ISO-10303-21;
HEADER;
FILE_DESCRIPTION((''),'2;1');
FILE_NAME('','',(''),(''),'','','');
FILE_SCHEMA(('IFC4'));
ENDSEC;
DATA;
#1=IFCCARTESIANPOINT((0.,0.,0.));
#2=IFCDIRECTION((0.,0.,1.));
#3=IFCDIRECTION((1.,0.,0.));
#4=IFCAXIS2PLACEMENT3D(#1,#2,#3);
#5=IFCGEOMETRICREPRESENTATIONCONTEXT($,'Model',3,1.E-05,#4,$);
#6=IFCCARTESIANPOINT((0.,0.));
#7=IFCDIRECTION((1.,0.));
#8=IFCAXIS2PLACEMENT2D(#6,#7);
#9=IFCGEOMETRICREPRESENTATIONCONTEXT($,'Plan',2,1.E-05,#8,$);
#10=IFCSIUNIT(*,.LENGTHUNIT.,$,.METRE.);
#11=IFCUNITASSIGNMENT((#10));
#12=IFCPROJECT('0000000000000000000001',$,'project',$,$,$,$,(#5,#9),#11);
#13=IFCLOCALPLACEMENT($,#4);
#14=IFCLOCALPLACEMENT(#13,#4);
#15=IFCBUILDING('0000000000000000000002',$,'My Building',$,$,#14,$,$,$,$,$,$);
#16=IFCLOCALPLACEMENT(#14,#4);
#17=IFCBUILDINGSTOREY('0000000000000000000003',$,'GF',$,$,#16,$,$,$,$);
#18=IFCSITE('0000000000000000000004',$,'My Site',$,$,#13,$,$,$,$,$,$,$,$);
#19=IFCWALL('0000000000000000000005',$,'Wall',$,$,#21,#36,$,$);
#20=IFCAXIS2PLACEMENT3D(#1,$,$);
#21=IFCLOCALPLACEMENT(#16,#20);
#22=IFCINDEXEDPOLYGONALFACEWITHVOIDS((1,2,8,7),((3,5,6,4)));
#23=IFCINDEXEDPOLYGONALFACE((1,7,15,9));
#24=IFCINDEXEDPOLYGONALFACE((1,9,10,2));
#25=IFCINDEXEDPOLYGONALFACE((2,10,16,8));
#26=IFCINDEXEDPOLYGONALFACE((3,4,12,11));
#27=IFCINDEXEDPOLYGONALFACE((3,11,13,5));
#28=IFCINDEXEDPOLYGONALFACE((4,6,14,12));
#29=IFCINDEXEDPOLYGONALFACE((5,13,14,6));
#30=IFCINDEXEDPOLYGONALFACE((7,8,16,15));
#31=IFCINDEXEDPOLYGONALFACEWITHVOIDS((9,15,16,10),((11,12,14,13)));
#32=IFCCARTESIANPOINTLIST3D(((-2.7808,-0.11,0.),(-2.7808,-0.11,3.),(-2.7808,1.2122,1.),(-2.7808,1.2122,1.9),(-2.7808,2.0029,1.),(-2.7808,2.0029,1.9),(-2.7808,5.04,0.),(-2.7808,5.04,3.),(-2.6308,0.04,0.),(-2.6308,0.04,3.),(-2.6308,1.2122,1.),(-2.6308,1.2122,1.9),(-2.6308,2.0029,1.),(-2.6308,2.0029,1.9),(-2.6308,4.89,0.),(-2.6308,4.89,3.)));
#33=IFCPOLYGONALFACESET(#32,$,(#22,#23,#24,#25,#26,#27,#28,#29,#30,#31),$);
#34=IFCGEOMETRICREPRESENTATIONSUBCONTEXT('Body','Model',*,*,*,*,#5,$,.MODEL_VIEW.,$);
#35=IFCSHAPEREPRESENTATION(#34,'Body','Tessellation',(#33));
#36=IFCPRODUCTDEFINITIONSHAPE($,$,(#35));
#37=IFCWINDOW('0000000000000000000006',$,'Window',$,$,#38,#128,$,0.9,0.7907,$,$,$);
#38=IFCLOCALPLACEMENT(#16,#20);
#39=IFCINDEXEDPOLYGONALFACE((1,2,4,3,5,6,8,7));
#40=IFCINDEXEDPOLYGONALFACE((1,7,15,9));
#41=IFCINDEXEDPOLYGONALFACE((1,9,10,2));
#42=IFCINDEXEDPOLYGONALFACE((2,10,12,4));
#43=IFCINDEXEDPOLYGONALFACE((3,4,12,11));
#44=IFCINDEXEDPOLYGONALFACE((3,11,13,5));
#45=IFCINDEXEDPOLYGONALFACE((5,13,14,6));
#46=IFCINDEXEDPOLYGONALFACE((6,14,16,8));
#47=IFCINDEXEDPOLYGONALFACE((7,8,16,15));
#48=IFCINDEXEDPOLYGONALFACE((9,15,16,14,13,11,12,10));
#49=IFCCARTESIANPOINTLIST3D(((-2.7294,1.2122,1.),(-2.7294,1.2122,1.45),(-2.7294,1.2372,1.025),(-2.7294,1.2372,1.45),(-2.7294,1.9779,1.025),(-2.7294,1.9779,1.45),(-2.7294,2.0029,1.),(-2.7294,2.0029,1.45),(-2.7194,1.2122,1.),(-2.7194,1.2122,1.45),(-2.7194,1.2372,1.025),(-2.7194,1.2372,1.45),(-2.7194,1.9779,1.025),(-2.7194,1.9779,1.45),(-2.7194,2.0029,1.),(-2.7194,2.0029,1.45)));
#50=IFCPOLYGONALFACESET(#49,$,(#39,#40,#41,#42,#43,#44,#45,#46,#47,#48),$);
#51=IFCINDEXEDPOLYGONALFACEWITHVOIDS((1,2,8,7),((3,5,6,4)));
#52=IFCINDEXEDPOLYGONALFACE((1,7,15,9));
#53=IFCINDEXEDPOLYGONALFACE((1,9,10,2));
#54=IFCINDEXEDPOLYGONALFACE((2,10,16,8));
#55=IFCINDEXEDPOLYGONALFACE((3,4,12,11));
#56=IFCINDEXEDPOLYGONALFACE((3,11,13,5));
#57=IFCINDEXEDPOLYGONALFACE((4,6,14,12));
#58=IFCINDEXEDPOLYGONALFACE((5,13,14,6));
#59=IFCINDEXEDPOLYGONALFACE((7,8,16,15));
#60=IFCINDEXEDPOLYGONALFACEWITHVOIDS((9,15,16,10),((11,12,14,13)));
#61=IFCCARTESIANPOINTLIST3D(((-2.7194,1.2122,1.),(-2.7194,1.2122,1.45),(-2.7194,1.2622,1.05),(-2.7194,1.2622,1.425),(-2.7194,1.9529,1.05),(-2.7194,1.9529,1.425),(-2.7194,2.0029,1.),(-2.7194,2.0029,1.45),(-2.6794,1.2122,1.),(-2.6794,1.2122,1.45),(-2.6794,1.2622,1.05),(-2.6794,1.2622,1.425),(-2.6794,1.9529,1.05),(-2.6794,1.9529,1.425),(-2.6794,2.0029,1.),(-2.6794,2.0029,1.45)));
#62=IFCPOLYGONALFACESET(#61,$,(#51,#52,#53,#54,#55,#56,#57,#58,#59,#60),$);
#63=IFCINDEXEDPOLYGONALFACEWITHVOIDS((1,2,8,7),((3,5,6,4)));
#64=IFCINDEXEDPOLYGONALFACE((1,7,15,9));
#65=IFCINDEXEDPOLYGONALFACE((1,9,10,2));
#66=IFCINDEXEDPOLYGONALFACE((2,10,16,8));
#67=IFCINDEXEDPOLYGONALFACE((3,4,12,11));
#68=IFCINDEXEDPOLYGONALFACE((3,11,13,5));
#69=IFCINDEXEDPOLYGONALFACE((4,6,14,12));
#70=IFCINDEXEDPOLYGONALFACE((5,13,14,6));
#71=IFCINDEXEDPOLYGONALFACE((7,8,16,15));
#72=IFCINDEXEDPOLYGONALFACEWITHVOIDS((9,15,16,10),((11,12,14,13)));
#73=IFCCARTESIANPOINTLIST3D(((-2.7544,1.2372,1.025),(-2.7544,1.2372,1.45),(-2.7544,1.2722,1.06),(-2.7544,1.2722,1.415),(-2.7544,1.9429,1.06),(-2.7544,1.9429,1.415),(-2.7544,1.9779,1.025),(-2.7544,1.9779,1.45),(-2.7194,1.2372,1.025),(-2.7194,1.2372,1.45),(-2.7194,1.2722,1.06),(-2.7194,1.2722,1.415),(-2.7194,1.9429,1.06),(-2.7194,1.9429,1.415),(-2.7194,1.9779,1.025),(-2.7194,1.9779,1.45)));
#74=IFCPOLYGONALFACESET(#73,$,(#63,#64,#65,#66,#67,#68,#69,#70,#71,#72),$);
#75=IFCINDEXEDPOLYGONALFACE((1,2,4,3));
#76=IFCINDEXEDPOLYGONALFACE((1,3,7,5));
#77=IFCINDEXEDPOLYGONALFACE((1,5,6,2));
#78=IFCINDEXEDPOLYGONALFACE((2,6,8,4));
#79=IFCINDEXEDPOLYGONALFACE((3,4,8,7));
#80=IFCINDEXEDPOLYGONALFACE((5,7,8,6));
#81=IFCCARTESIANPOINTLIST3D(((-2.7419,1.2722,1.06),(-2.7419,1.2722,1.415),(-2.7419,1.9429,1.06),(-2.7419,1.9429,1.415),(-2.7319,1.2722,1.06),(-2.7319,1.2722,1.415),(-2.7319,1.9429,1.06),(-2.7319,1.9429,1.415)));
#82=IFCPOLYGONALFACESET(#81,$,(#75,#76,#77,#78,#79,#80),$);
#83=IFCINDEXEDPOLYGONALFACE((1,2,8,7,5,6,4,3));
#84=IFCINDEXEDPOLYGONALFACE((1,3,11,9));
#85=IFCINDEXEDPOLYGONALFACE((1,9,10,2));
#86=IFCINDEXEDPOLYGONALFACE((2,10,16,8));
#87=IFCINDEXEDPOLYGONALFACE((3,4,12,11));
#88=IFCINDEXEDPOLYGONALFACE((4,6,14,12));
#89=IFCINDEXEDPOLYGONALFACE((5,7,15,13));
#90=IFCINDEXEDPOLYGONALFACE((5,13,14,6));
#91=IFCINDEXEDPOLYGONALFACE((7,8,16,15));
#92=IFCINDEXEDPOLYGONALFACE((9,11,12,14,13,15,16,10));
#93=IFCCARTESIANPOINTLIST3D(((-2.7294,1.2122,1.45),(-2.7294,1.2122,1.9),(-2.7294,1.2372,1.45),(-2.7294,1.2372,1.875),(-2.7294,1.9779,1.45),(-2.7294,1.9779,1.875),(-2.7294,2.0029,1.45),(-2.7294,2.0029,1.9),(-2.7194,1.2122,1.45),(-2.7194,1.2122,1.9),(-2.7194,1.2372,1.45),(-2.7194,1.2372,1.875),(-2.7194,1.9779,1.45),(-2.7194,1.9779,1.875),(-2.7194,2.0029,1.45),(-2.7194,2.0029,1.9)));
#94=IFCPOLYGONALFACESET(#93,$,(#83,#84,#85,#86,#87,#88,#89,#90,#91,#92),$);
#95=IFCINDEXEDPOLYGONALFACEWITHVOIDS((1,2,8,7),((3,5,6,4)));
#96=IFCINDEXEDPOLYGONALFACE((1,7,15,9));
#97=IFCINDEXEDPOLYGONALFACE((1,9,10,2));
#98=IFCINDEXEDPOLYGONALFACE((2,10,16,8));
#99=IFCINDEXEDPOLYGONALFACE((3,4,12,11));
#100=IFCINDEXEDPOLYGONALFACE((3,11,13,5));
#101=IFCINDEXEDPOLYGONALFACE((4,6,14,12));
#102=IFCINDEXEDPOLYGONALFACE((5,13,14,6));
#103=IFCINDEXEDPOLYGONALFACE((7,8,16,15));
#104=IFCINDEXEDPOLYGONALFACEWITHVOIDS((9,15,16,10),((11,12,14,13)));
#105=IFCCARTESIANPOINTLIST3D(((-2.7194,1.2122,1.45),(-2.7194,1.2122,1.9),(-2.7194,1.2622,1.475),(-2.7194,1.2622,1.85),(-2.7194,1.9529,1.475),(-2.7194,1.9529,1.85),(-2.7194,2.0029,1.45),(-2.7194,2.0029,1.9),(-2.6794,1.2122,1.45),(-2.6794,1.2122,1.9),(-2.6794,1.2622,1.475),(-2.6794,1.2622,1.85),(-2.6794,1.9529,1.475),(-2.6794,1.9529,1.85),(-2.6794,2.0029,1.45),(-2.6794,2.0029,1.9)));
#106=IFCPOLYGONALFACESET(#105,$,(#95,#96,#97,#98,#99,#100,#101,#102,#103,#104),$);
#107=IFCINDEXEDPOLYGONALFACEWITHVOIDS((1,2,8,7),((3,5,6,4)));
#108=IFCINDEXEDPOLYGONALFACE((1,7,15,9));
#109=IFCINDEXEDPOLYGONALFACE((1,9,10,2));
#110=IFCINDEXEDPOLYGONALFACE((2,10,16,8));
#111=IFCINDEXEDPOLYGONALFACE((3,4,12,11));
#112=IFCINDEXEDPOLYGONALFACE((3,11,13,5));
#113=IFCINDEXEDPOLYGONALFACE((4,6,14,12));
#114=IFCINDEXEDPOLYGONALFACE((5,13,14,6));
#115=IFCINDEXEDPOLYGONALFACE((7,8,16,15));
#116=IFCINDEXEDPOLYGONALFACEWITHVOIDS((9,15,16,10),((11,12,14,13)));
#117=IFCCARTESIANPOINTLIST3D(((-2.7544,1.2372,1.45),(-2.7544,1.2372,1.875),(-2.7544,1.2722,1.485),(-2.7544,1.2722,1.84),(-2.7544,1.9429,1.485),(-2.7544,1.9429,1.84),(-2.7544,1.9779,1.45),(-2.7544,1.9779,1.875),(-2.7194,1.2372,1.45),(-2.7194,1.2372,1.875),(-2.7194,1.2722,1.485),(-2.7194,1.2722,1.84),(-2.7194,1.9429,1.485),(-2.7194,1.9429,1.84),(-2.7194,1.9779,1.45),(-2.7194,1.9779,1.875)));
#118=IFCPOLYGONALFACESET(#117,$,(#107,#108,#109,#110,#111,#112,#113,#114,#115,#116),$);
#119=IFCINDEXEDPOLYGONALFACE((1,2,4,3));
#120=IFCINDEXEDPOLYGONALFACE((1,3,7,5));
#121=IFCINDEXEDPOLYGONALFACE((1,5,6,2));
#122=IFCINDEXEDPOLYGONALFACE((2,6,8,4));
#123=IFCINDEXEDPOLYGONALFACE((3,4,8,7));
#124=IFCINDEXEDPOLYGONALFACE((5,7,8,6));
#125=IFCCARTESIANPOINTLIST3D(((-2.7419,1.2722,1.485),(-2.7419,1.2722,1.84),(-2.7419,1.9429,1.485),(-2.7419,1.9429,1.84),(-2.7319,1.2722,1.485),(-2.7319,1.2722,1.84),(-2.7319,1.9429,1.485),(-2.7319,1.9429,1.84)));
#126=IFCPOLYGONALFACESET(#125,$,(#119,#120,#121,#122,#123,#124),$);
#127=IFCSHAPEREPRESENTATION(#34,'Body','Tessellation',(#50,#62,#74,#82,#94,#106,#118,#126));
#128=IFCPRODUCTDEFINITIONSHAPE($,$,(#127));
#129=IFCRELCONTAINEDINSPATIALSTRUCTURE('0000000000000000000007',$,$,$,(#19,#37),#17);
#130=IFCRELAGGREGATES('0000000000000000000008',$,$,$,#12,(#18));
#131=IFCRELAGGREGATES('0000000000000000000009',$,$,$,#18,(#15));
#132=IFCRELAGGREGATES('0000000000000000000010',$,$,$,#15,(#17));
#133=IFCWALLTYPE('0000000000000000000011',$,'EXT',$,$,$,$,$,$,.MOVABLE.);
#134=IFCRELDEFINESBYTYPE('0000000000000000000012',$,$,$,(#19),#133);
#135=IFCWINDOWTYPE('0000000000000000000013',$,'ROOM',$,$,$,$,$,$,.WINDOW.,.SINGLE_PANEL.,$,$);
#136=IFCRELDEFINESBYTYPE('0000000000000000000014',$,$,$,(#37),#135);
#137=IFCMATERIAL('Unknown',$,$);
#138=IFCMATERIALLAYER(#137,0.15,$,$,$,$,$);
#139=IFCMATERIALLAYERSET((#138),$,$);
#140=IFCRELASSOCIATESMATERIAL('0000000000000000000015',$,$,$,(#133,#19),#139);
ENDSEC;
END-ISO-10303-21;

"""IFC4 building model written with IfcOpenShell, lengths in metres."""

from ifc_helpers import new_model, entity, si_unit, frame, origin_with_axes, origin_2d_with_axis, place, context, subcontext, project, spatial, line, indexed_curve, outline, extrude, shape, source, transform, mapped, material, layer, layer_set, layer_usage, type_object, type_shapes, element, fill, save


model = new_model("IFC4")

# Units and contexts
model_context = context("Model", 3, precision=1e-05, world=origin_with_axes())
plan_context = context("Plan", 2, precision=1e-05, world=origin_2d_with_axis())
body_context_1 = subcontext(model_context, "Body", "Model", "MODEL_VIEW")
body_context_2 = subcontext(plan_context, "Body", "Plan", "PLAN_VIEW")
ifc_project = project(units=[si_unit("LENGTHUNIT", "METRE")], contexts=[model_context, plan_context])

# Site, building, storey
site_placement = place(None, origin_with_axes())
site = spatial("IfcSite", under=ifc_project, at=site_placement, Name="My Site")
building_placement = place(site_placement, origin_with_axes())
building = spatial("IfcBuilding", under=site, at=building_placement, Name="My Building")
storey_placement = place(building_placement, origin_with_axes())
storey = spatial("IfcBuildingStorey", under=building, at=storey_placement, Name="GF")

# Shared definitions
ifc_material = material(Name="Unknown")

# Shared definitions
ifc_layer_1 = layer(ifc_material, 0.15)
ifc_layer_set_1 = layer_set([ifc_layer_1])
wall_type_1 = type_object("IfcWallType", Name="EXT", PredefinedType="MOVABLE", material=ifc_layer_set_1)
window_type_1 = type_object("IfcWindowType", Name="ROOM", PartitioningType="SINGLE_PANEL", PredefinedType="WINDOW")
shared_shape_1 = source(origin_with_axes(), body_context_1, "Body", "SweptSolid", [
    extrude(outline(indexed_curve([(0.7907, 0.45), (0.7907, 0.0), (0.0, 0.0), (0.0, 0.45), (0.025, 0.45), (0.025, 0.025), (0.7657, 0.025), (0.7657, 0.45)], segments=[line(1, 2, 3, 4, 5, 6, 7, 8, 1)])), frame((0.0, 0.09, 0.0), z_axis=(0.0, -1.0, 0.0), x_axis=(1.0, 0.0, 0.0)), (0.0, 0.0, -1.0), 0.01),
    extrude(outline(indexed_curve([(0.0, 0.0), (0.7907, 0.0), (0.7907, 0.45), (0.0, 0.45)], segments=[line(1, 2, 3, 4, 1)]), holes=[indexed_curve([(0.05, 0.05), (0.7407, 0.05), (0.7407, 0.425), (0.05, 0.425)], segments=[line(1, 2, 3, 4, 1)])]), frame((0.0, 0.05, 0.0), z_axis=(0.0, -1.0, 0.0), x_axis=(1.0, 0.0, 0.0)), (0.0, 0.0, -1.0), 0.04),
    extrude(outline(indexed_curve([(0.0, 0.0), (0.7407, 0.0), (0.7407, 0.425), (0.0, 0.425)], segments=[line(1, 2, 3, 4, 1)]), holes=[indexed_curve([(0.035, 0.035), (0.7057, 0.035), (0.7057, 0.39), (0.035, 0.39)], segments=[line(1, 2, 3, 4, 1)])]), frame((0.025, 0.09, 0.025), z_axis=(0.0, -1.0, 0.0), x_axis=(1.0, 0.0, 0.0)), (0.0, 0.0, -1.0), 0.035),
    extrude(outline(indexed_curve([(0.035, 0.035), (0.7057, 0.035), (0.7057, 0.39), (0.035, 0.39)], segments=[line(1, 2, 3, 4, 1)])), frame((0.025, 0.1025, 0.025), z_axis=(0.0, -1.0, 0.0), x_axis=(1.0, 0.0, 0.0)), (0.0, 0.0, -1.0), 0.01),
    extrude(outline(indexed_curve([(0.0, 0.0), (0.0, 0.45), (0.7907, 0.45), (0.7907, 0.0), (0.7657, 0.0), (0.7657, 0.425), (0.025, 0.425), (0.025, 0.0)], segments=[line(1, 2, 3, 4, 5, 6, 7, 8, 1)])), frame((0.0, 0.09, 0.45), z_axis=(0.0, -1.0, 0.0), x_axis=(1.0, 0.0, 0.0)), (0.0, 0.0, -1.0), 0.01),
    extrude(outline(indexed_curve([(0.0, 0.0), (0.7907, 0.0), (0.7907, 0.45), (0.0, 0.45)], segments=[line(1, 2, 3, 4, 1)]), holes=[indexed_curve([(0.05, 0.025), (0.7407, 0.025), (0.7407, 0.4), (0.05, 0.4)], segments=[line(1, 2, 3, 4, 1)])]), frame((0.0, 0.05, 0.45), z_axis=(0.0, -1.0, 0.0), x_axis=(1.0, 0.0, 0.0)), (0.0, 0.0, -1.0), 0.04),
    extrude(outline(indexed_curve([(0.0, 0.0), (0.7407, 0.0), (0.7407, 0.425), (0.0, 0.425)], segments=[line(1, 2, 3, 4, 1)]), holes=[indexed_curve([(0.035, 0.035), (0.7057, 0.035), (0.7057, 0.39), (0.035, 0.39)], segments=[line(1, 2, 3, 4, 1)])]), frame((0.025, 0.09, 0.45), z_axis=(0.0, -1.0, 0.0), x_axis=(1.0, 0.0, 0.0)), (0.0, 0.0, -1.0), 0.035),
    extrude(outline(indexed_curve([(0.035, 0.035), (0.7057, 0.035), (0.7057, 0.39), (0.035, 0.39)], segments=[line(1, 2, 3, 4, 1)])), frame((0.025, 0.1025, 0.45), z_axis=(0.0, -1.0, 0.0), x_axis=(1.0, 0.0, 0.0)), (0.0, 0.0, -1.0), 0.01),
])
shared_shape_2 = source(origin_with_axes(), body_context_2, "Body", "Curve2D", [
    entity("IfcIndexedPolyCurve", entity("IfcCartesianPointList2D", [[0.05, 0.05], [0.7407, 0.05]])),
    entity("IfcIndexedPolyCurve", entity("IfcCartesianPointList2D", [[0.0, 0.1], [0.025, 0.1], [0.025, 0.09], [0.05, 0.09], [0.05, 0.05], [0.0, 0.05]]), [entity("IfcLineIndex", [1, 2, 3, 4, 5, 6, 1])]),
    entity("IfcIndexedPolyCurve", entity("IfcCartesianPointList2D", [[0.7907, 0.1], [0.7657, 0.1], [0.7657, 0.09], [0.7407, 0.09], [0.7407, 0.05], [0.7907, 0.05]]), [entity("IfcLineIndex", [1, 2, 3, 4, 5, 6, 1])]),
    entity("IfcIndexedPolyCurve", entity("IfcCartesianPointList2D", [[0.025, 0.09], [0.06, 0.09], [0.06, 0.125], [0.025, 0.125]]), [entity("IfcLineIndex", [1, 2, 3, 4, 1])]),
    entity("IfcIndexedPolyCurve", entity("IfcCartesianPointList2D", [[0.7657, 0.09], [0.7307, 0.09], [0.7307, 0.125], [0.7657, 0.125]]), [entity("IfcLineIndex", [1, 2, 3, 4, 1])]),
    entity("IfcIndexedPolyCurve", entity("IfcCartesianPointList2D", [[0.06, 0.09], [0.7307, 0.09]])),
    entity("IfcIndexedPolyCurve", entity("IfcCartesianPointList2D", [[0.06, 0.125], [0.7307, 0.125]])),
    entity("IfcIndexedPolyCurve", entity("IfcCartesianPointList2D", [[0.06, 0.1075], [0.7307, 0.1075]])),
])
type_shapes(window_type_1, [shared_shape_1, shared_shape_2])

# Wall, opening, window
ifc_layer_usage_1 = layer_usage(ifc_layer_set_1, "AXIS2", "POSITIVE", 0.0)
wall_1_placement = place(storey_placement, frame((-2.7808, 5.04, 0.0), z_axis=(0.0, 0.0, 1.0), x_axis=(0.0, -1.0, 0.0)))
wall_1 = element("IfcWall", 1, at=wall_1_placement, inside=storey, type_object=wall_type_1, material=ifc_layer_usage_1, Name="Wall", context=body_context_1, shape_type="SweptSolid", body=[
    extrude(outline(indexed_curve([(0.0, 0.0), (0.15, 0.15), (5.0, 0.15), (5.15, 0.0)], segments=[line(1, 2, 3, 4, 1)])), origin_with_axes(), (0.0, 0.0, 1.0), 3.0),
])
placement_1 = place(storey_placement, frame((-2.6294, 1.2122, 1.0), z_axis=(0.0, 0.0, 1.0), x_axis=(0.0, 1.0, 0.0)))
opening_1 = element("IfcOpeningElement", 2, at=placement_1, cuts=wall_1, PredefinedType="OPENING", context=body_context_1, shape_type="SweptSolid", body=[
    extrude(outline(indexed_curve([(0.0, 0.0), (0.7907, 0.0), (0.7907, 0.9), (0.0, 0.9)], segments=[line(1, 2, 3, 4, 1)])), frame((0.0, -0.6, 0.0), z_axis=(0.0, -1.0, 0.0), x_axis=(1.0, 0.0, 0.0)), (0.0, 0.0, -1.0), 1.2),
])
window_1 = element("IfcWindow", 3, at=placement_1, inside=storey, type_object=window_type_1, Name="Window", OverallHeight=0.9, OverallWidth=0.7907, shapes=[
    shape(body_context_1, "Body", "MappedRepresentation", [mapped(shared_shape_1, transform((0.0, 0.0, 0.0), x_axis=(1.0, 0.0, 0.0), y_axis=(0.0, 1.0, 0.0), z_axis=(0.0, 0.0, 1.0), scale=1.0))]),
    shape(body_context_2, "Body", "MappedRepresentation", [mapped(shared_shape_2, transform((0.0, 0.0, 0.0), x_axis=(1.0, 0.0, 0.0), y_axis=(0.0, 1.0, 0.0), z_axis=(0.0, 0.0, 1.0), scale=1.0))]),
])
fill(opening_1, window_1)

save(model, "model.ifc")
